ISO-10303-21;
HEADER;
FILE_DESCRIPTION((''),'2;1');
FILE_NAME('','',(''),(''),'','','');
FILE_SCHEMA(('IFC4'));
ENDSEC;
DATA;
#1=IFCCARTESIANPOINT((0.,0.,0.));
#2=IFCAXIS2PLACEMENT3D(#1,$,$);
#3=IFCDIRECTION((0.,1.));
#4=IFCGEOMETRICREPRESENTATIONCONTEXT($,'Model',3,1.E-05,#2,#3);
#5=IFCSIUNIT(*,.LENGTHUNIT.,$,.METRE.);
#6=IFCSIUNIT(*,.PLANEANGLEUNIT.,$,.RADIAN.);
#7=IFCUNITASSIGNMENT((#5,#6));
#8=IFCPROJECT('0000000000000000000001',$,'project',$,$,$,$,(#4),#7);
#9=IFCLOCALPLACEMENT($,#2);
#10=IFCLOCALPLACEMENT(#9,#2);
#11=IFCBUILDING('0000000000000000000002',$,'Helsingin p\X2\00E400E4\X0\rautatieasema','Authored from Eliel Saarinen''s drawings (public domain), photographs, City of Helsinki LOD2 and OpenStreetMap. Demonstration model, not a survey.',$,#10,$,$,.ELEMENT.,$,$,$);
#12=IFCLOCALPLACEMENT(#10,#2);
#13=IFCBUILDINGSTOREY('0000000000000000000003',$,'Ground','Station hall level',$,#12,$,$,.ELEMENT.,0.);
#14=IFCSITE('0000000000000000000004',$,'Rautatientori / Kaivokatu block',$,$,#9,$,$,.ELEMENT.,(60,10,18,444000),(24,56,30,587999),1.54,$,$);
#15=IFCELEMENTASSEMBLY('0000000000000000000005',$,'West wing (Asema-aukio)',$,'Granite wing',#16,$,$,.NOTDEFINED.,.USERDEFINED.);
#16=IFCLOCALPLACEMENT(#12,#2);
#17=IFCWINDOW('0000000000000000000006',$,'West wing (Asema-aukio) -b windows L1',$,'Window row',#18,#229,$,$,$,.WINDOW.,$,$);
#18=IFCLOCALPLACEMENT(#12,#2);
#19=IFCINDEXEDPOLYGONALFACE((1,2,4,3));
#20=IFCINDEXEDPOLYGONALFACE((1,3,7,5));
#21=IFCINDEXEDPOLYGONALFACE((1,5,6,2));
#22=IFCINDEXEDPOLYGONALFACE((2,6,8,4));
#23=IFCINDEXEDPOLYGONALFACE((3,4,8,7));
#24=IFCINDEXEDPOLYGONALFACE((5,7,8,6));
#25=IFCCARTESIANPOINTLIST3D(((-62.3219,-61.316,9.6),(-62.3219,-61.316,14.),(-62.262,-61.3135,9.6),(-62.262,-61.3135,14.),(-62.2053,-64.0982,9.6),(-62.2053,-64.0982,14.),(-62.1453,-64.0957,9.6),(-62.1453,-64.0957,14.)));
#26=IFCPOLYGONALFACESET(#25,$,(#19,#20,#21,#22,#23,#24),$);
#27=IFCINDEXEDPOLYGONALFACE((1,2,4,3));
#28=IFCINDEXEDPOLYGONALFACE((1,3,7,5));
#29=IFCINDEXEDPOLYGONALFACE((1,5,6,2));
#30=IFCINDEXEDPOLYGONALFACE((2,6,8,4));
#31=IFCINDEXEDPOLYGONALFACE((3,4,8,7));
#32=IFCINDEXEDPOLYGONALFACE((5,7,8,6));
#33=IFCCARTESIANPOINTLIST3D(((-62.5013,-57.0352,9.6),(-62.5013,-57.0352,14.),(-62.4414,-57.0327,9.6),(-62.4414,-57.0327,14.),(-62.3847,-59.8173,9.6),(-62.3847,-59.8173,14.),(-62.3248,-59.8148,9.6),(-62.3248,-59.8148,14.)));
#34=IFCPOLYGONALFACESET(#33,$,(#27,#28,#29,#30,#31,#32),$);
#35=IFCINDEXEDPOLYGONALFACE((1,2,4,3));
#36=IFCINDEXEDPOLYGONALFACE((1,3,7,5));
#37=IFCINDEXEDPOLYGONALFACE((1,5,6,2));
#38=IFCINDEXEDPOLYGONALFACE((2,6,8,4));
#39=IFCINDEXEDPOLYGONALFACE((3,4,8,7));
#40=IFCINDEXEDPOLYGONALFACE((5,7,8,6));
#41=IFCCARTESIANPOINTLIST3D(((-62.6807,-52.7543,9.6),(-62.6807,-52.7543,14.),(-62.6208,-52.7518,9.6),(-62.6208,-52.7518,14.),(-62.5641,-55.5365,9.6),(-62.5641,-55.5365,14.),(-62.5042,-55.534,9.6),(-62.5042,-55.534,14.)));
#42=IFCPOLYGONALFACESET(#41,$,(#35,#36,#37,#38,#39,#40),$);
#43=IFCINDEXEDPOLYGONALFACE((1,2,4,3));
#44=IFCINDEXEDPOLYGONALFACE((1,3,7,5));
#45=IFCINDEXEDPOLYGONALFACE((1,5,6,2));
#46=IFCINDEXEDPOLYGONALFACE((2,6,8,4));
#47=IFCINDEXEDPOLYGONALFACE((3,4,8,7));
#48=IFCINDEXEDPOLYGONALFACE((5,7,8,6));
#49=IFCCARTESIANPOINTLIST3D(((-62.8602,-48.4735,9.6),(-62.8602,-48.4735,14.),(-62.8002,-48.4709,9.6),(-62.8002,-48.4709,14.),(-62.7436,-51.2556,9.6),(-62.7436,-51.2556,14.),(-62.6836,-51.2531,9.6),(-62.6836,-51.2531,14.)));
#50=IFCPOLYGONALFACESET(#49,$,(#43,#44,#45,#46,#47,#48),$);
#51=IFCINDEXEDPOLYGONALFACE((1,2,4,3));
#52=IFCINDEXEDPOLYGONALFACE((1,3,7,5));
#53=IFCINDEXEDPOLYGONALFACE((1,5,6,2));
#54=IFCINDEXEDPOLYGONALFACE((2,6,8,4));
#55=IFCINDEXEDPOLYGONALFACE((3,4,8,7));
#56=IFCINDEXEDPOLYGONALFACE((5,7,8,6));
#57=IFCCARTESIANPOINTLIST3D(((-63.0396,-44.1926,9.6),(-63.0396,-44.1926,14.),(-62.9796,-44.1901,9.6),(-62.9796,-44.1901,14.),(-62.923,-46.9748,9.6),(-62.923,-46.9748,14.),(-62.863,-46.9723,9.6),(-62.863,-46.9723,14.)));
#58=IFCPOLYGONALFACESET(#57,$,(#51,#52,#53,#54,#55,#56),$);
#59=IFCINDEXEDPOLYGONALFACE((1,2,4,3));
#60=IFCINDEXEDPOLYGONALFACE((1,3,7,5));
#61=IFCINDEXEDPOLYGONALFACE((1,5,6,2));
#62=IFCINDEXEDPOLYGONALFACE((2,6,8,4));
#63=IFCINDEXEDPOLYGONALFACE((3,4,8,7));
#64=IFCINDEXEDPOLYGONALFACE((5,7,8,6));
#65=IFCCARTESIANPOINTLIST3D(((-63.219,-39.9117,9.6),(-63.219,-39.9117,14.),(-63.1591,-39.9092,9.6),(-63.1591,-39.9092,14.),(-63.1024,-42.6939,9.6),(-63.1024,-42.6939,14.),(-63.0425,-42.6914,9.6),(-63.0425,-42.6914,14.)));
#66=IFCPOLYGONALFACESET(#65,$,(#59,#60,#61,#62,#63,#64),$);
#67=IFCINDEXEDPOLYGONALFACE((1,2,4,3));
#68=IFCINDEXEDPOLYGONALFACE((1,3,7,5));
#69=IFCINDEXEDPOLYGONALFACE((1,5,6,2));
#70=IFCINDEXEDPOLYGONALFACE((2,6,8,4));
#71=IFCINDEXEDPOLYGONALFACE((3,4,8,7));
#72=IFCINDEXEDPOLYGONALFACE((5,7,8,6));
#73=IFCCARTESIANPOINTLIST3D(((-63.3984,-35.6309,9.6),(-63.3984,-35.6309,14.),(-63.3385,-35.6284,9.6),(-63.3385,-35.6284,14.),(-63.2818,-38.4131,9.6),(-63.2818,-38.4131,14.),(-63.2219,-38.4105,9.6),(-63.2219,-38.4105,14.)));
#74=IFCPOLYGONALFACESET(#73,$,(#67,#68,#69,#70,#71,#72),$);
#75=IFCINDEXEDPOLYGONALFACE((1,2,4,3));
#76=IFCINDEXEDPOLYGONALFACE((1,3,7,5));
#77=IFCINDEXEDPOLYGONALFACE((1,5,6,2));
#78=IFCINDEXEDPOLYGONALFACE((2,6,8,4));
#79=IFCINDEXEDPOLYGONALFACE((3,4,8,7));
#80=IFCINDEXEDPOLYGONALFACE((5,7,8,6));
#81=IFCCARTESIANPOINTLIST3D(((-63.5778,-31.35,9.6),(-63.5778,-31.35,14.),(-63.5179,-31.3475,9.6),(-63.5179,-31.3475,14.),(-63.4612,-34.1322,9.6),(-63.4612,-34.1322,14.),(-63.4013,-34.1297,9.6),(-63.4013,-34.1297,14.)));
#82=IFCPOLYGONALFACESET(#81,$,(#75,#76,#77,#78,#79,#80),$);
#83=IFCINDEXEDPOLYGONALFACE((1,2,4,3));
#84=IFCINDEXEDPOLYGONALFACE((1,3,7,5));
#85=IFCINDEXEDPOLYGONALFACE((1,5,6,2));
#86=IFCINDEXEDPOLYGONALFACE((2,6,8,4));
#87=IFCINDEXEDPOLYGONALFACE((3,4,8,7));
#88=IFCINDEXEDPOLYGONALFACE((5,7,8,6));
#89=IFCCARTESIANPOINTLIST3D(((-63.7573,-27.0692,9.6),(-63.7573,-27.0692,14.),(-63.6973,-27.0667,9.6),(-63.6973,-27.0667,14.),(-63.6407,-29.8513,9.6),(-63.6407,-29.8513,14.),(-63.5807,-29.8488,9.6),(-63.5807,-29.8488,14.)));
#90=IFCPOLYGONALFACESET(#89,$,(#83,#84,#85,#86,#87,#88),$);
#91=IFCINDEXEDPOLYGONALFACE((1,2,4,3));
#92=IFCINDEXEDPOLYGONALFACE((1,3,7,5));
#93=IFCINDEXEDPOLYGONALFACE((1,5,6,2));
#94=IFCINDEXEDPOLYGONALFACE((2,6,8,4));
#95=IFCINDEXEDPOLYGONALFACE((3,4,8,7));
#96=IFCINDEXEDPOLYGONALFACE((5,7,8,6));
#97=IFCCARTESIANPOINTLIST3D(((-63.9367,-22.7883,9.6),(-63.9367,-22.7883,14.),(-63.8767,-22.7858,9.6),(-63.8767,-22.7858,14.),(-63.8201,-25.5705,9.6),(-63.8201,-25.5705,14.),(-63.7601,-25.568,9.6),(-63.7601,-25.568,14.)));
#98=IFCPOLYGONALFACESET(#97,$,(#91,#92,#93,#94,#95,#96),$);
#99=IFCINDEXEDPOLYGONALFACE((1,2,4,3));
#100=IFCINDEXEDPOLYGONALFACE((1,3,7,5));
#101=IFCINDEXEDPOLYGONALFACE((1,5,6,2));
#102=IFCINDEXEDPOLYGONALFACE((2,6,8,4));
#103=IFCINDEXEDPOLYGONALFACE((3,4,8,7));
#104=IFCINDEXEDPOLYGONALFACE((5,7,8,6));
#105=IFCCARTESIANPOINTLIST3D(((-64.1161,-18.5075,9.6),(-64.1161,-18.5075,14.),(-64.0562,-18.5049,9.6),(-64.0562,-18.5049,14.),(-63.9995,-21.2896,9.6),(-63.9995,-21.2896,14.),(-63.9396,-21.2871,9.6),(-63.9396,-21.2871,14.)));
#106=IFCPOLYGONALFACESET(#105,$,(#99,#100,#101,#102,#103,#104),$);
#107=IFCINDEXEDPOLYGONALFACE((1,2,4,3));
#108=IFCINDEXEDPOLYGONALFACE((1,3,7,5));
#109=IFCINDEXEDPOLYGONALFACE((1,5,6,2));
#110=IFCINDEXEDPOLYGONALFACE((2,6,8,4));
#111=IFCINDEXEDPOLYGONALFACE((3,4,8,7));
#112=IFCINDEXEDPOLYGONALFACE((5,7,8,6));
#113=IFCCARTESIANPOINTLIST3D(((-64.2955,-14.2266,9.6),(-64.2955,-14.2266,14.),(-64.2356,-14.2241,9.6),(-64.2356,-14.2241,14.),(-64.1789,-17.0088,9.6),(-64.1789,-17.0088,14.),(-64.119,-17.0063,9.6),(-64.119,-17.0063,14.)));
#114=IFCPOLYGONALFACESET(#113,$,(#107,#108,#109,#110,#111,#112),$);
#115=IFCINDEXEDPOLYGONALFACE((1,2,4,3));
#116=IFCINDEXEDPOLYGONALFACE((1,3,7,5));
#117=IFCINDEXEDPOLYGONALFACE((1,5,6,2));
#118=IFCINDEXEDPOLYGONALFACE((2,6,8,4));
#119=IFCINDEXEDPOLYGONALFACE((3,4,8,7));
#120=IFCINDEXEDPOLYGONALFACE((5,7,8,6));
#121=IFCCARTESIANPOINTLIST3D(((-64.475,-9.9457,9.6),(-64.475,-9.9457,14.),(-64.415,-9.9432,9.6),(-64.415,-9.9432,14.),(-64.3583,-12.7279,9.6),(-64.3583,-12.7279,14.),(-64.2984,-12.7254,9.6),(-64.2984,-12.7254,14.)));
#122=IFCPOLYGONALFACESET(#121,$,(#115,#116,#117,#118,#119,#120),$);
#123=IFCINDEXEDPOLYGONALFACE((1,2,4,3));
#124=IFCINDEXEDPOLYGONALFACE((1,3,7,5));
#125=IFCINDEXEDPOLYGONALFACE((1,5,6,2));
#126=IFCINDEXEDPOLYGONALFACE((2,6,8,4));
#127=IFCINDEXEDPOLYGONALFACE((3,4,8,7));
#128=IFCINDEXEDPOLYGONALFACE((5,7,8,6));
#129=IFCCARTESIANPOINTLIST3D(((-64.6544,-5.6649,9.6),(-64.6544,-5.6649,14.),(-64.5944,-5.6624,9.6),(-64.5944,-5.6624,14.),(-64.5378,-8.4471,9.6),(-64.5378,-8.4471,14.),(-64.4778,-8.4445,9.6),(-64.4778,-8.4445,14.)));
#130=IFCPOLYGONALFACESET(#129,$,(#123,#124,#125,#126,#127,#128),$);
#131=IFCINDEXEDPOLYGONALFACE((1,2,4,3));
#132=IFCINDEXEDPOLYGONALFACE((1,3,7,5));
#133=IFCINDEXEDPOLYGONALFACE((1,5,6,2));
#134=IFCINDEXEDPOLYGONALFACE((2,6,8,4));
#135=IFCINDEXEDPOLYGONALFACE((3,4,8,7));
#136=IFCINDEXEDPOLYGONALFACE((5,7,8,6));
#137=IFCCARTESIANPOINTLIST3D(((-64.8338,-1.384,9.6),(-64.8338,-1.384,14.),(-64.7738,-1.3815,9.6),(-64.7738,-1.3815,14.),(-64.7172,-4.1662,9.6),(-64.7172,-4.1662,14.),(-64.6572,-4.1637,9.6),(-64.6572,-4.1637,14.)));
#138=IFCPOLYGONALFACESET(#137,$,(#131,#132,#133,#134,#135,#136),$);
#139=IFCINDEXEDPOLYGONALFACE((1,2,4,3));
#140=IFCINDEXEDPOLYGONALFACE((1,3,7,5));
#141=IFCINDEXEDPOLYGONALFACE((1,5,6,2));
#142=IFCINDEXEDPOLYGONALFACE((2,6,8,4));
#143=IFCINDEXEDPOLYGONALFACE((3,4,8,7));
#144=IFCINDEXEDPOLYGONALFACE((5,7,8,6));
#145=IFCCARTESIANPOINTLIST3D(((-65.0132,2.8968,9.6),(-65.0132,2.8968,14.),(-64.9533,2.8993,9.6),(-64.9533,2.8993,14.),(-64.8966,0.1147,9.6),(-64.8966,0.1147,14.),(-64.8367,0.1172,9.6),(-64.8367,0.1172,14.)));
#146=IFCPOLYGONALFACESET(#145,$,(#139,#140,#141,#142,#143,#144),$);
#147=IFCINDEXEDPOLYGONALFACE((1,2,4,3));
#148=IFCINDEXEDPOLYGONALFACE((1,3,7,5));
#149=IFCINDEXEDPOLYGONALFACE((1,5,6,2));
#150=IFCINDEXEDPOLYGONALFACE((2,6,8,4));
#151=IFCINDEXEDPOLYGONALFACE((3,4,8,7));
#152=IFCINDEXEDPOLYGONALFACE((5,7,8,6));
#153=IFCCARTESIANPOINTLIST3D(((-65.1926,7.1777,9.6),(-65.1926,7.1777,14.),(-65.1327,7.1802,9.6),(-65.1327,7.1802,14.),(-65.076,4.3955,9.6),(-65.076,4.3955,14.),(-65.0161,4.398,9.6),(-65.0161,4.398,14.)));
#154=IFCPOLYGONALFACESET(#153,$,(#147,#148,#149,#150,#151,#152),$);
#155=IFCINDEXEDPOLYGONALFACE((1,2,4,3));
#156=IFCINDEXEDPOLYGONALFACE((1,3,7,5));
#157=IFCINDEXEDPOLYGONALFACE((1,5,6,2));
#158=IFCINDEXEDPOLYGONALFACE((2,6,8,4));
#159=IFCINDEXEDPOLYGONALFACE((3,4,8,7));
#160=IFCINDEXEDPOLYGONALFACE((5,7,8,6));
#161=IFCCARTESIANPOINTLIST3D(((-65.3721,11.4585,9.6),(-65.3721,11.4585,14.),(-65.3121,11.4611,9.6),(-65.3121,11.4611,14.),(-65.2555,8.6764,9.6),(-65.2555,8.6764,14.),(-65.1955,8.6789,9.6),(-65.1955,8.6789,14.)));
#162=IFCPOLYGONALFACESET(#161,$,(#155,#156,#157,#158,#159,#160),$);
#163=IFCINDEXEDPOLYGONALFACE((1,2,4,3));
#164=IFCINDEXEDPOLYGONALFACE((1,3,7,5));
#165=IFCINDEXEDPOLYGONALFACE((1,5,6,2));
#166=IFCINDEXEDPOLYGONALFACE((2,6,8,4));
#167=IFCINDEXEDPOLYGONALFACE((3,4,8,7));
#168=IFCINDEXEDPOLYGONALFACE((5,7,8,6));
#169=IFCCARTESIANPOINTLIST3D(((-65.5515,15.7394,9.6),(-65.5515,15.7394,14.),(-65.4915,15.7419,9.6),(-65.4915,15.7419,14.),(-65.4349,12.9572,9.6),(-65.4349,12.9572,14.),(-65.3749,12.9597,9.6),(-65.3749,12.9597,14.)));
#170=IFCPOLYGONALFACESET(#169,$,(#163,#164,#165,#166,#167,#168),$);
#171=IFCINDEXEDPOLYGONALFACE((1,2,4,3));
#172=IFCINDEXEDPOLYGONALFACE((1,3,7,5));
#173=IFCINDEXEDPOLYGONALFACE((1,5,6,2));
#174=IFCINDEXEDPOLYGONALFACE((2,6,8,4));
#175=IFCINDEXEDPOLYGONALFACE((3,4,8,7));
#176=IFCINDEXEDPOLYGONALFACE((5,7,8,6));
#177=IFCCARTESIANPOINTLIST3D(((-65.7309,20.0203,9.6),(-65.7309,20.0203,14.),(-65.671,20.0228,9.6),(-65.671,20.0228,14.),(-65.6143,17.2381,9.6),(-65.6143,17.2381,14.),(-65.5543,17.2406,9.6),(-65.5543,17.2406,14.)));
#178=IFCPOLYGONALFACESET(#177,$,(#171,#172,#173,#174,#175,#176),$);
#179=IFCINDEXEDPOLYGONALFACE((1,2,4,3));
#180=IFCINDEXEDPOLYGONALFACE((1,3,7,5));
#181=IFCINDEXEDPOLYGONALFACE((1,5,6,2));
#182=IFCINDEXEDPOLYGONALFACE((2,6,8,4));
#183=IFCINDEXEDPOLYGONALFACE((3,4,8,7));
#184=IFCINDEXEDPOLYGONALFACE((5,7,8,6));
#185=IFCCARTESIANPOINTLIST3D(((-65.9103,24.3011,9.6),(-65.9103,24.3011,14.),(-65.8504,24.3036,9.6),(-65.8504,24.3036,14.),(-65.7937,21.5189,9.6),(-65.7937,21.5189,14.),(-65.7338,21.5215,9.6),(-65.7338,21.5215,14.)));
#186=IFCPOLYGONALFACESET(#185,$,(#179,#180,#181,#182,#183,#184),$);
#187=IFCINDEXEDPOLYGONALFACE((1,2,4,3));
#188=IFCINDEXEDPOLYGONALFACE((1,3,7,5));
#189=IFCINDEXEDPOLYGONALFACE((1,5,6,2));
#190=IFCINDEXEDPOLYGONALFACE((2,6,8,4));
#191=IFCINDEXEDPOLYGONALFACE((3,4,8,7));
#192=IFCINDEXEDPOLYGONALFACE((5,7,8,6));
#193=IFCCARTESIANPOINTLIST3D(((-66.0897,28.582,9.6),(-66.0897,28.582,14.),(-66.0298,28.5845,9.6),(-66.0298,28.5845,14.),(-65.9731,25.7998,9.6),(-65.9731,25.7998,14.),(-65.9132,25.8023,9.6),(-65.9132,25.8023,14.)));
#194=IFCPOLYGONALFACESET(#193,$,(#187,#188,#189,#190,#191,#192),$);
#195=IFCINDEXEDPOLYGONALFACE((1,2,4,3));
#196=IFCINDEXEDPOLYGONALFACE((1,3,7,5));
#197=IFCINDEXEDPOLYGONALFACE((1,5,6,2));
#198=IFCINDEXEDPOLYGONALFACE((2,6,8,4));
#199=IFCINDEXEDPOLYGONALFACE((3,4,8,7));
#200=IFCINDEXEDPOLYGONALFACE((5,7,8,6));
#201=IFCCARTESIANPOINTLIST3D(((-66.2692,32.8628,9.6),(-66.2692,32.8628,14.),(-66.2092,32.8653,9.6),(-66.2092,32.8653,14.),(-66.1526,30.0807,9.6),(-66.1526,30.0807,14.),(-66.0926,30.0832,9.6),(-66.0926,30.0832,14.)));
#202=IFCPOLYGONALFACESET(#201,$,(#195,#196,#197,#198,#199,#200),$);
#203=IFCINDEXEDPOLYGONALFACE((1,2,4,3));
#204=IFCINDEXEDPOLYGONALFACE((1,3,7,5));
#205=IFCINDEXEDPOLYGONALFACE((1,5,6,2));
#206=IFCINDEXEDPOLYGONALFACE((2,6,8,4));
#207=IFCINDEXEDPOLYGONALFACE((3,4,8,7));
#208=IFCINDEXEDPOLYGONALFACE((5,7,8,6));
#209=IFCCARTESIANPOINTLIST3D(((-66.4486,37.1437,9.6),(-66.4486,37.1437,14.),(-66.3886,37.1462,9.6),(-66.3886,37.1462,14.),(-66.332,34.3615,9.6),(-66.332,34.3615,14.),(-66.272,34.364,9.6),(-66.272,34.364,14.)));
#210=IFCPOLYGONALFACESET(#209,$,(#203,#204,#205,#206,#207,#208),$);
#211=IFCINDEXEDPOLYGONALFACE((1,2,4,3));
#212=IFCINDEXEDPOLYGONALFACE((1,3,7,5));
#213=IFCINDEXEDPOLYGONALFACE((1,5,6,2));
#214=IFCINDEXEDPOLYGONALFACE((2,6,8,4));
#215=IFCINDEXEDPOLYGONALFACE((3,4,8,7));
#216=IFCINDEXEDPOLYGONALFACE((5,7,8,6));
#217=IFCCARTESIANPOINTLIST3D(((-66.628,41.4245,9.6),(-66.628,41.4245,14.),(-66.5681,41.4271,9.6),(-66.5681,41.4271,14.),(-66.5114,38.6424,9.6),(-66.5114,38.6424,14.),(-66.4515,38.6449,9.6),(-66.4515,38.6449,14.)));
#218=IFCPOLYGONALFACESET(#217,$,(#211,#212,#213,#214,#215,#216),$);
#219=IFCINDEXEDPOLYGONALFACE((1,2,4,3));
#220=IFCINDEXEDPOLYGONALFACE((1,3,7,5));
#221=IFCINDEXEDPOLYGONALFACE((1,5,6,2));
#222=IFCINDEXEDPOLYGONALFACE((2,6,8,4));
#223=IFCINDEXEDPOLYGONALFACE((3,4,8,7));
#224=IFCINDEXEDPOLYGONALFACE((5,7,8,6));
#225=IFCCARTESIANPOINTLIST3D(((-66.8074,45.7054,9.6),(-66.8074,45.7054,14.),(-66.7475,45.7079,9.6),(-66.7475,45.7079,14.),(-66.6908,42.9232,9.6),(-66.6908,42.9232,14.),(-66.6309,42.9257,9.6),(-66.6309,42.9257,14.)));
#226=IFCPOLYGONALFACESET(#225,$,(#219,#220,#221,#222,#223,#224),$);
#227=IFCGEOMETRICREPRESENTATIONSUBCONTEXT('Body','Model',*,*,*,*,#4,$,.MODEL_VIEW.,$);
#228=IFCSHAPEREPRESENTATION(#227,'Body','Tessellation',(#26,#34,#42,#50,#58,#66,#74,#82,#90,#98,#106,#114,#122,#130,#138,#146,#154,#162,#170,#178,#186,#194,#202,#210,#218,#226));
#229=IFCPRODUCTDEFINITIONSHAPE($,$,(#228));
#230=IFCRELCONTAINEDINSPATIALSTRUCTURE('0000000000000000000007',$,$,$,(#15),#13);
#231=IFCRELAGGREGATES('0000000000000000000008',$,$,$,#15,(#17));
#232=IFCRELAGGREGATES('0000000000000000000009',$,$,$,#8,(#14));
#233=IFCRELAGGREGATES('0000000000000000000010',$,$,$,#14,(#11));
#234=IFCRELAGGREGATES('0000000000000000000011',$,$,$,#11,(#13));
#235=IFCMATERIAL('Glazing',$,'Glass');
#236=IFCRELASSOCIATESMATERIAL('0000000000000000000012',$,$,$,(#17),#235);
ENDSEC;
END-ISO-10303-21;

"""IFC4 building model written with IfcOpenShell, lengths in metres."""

from ifc_helpers import new_model, si_unit, direction, frame, frame_2d, origin, place, context, subcontext, project, spatial, rectangle, extrude, material, element, aggregate, save


model = new_model("IFC4")

# Units and contexts
model_context = context("Model", 3, precision=1e-05, world=origin(), true_north=direction((0.0, 1.0)))
body_context = subcontext(model_context, "Body", "Model", "MODEL_VIEW")
ifc_project = project(units=[si_unit("LENGTHUNIT", "METRE"), si_unit("PLANEANGLEUNIT", "RADIAN")], contexts=[model_context])

# Site, building, storey
site_placement = place(None, origin())
site = spatial("IfcSite", under=ifc_project, at=site_placement, Name="Rautatientori / Kaivokatu block", CompositionType="ELEMENT", RefLatitude=(60, 10, 18, 444000), RefLongitude=(24, 56, 30, 587999), RefElevation=1.54)
building_placement = place(site_placement, origin())
building = spatial("IfcBuilding", under=site, at=building_placement, Name="Helsingin päärautatieasema", Description="Authored from Eliel Saarinen's drawings (public domain), photographs, City of Helsinki LOD2 and OpenStreetMap. Demonstration model, not a survey.", CompositionType="ELEMENT")
storey_placement = place(building_placement, origin())
storey = spatial("IfcBuildingStorey", under=building, at=storey_placement, Name="Ground", Description="Station hall level", CompositionType="ELEMENT", Elevation=0.0)

# Element assembly, window
assembly_placement = place(building_placement, origin())
assembly = element("IfcElementAssembly", 1, at=assembly_placement, inside=storey, Name="West wing (Asema-aukio)", ObjectType="Granite wing", AssemblyPlace="NOTDEFINED", PredefinedType="USERDEFINED")
ifc_material_1 = material(Name="Glazing", Category="Glass")
window_1_placement = place(building_placement, origin())
window_1 = element("IfcWindow", 2, at=window_1_placement, material=ifc_material_1, Name="West wing (Asema-aukio) -b windows L1", ObjectType="Window row", PredefinedType="WINDOW", context=body_context, shape_type="SweptSolid", body=[
    extrude(rectangle(XDim=2.7846, YDim=0.06, at=frame_2d((0.0, 0.0), x_axis=(-0.041876, 0.999123))), frame((-62.2336, -62.7059, 9.6)), (0.0, 0.0, 1.0), 4.4),
    extrude(rectangle(XDim=2.7846, YDim=0.06, at=frame_2d((0.0, 0.0), x_axis=(-0.041876, 0.999123))), frame((-62.413, -58.425, 9.6)), (0.0, 0.0, 1.0), 4.4),
    extrude(rectangle(XDim=2.7846, YDim=0.06, at=frame_2d((0.0, 0.0), x_axis=(-0.041876, 0.999123))), frame((-62.5925, -54.1441, 9.6)), (0.0, 0.0, 1.0), 4.4),
    extrude(rectangle(XDim=2.7846, YDim=0.06, at=frame_2d((0.0, 0.0), x_axis=(-0.041876, 0.999123))), frame((-62.7719, -49.8633, 9.6)), (0.0, 0.0, 1.0), 4.4),
    extrude(rectangle(XDim=2.7846, YDim=0.06, at=frame_2d((0.0, 0.0), x_axis=(-0.041876, 0.999123))), frame((-62.9513, -45.5824, 9.6)), (0.0, 0.0, 1.0), 4.4),
    extrude(rectangle(XDim=2.7846, YDim=0.06, at=frame_2d((0.0, 0.0), x_axis=(-0.041876, 0.999123))), frame((-63.1307, -41.3016, 9.6)), (0.0, 0.0, 1.0), 4.4),
    extrude(rectangle(XDim=2.7846, YDim=0.06, at=frame_2d((0.0, 0.0), x_axis=(-0.041876, 0.999123))), frame((-63.3101, -37.0207, 9.6)), (0.0, 0.0, 1.0), 4.4),
    extrude(rectangle(XDim=2.7846, YDim=0.06, at=frame_2d((0.0, 0.0), x_axis=(-0.041876, 0.999123))), frame((-63.4896, -32.7399, 9.6)), (0.0, 0.0, 1.0), 4.4),
    extrude(rectangle(XDim=2.7846, YDim=0.06, at=frame_2d((0.0, 0.0), x_axis=(-0.041876, 0.999123))), frame((-63.669, -28.459, 9.6)), (0.0, 0.0, 1.0), 4.4),
    extrude(rectangle(XDim=2.7846, YDim=0.06, at=frame_2d((0.0, 0.0), x_axis=(-0.041876, 0.999123))), frame((-63.8484, -24.1781, 9.6)), (0.0, 0.0, 1.0), 4.4),
    extrude(rectangle(XDim=2.7846, YDim=0.06, at=frame_2d((0.0, 0.0), x_axis=(-0.041876, 0.999123))), frame((-64.0278, -19.8973, 9.6)), (0.0, 0.0, 1.0), 4.4),
    extrude(rectangle(XDim=2.7846, YDim=0.06, at=frame_2d((0.0, 0.0), x_axis=(-0.041876, 0.999123))), frame((-64.2073, -15.6164, 9.6)), (0.0, 0.0, 1.0), 4.4),
    extrude(rectangle(XDim=2.7846, YDim=0.06, at=frame_2d((0.0, 0.0), x_axis=(-0.041876, 0.999123))), frame((-64.3867, -11.3356, 9.6)), (0.0, 0.0, 1.0), 4.4),
    extrude(rectangle(XDim=2.7846, YDim=0.06, at=frame_2d((0.0, 0.0), x_axis=(-0.041876, 0.999123))), frame((-64.5661, -7.0547, 9.6)), (0.0, 0.0, 1.0), 4.4),
    extrude(rectangle(XDim=2.7846, YDim=0.06, at=frame_2d((0.0, 0.0), x_axis=(-0.041876, 0.999123))), frame((-64.7455, -2.7739, 9.6)), (0.0, 0.0, 1.0), 4.4),
    extrude(rectangle(XDim=2.7846, YDim=0.06, at=frame_2d((0.0, 0.0), x_axis=(-0.041876, 0.999123))), frame((-64.9249, 1.507, 9.6)), (0.0, 0.0, 1.0), 4.4),
    extrude(rectangle(XDim=2.7846, YDim=0.06, at=frame_2d((0.0, 0.0), x_axis=(-0.041876, 0.999123))), frame((-65.1044, 5.7879, 9.6)), (0.0, 0.0, 1.0), 4.4),
    extrude(rectangle(XDim=2.7846, YDim=0.06, at=frame_2d((0.0, 0.0), x_axis=(-0.041876, 0.999123))), frame((-65.2838, 10.0687, 9.6)), (0.0, 0.0, 1.0), 4.4),
    extrude(rectangle(XDim=2.7846, YDim=0.06, at=frame_2d((0.0, 0.0), x_axis=(-0.041876, 0.999123))), frame((-65.4632, 14.3496, 9.6)), (0.0, 0.0, 1.0), 4.4),
    extrude(rectangle(XDim=2.7846, YDim=0.06, at=frame_2d((0.0, 0.0), x_axis=(-0.041876, 0.999123))), frame((-65.6426, 18.6304, 9.6)), (0.0, 0.0, 1.0), 4.4),
    extrude(rectangle(XDim=2.7846, YDim=0.06, at=frame_2d((0.0, 0.0), x_axis=(-0.041876, 0.999123))), frame((-65.822, 22.9113, 9.6)), (0.0, 0.0, 1.0), 4.4),
    extrude(rectangle(XDim=2.7846, YDim=0.06, at=frame_2d((0.0, 0.0), x_axis=(-0.041876, 0.999123))), frame((-66.0015, 27.1921, 9.6)), (0.0, 0.0, 1.0), 4.4),
    extrude(rectangle(XDim=2.7846, YDim=0.06, at=frame_2d((0.0, 0.0), x_axis=(-0.041876, 0.999123))), frame((-66.1809, 31.473, 9.6)), (0.0, 0.0, 1.0), 4.4),
    extrude(rectangle(XDim=2.7846, YDim=0.06, at=frame_2d((0.0, 0.0), x_axis=(-0.041876, 0.999123))), frame((-66.3603, 35.7539, 9.6)), (0.0, 0.0, 1.0), 4.4),
    extrude(rectangle(XDim=2.7846, YDim=0.06, at=frame_2d((0.0, 0.0), x_axis=(-0.041876, 0.999123))), frame((-66.5397, 40.0347, 9.6)), (0.0, 0.0, 1.0), 4.4),
    extrude(rectangle(XDim=2.7846, YDim=0.06, at=frame_2d((0.0, 0.0), x_axis=(-0.041876, 0.999123))), frame((-66.7191, 44.3156, 9.6)), (0.0, 0.0, 1.0), 4.4),
])
aggregate(assembly, [window_1])

save(model, "model.ifc")
